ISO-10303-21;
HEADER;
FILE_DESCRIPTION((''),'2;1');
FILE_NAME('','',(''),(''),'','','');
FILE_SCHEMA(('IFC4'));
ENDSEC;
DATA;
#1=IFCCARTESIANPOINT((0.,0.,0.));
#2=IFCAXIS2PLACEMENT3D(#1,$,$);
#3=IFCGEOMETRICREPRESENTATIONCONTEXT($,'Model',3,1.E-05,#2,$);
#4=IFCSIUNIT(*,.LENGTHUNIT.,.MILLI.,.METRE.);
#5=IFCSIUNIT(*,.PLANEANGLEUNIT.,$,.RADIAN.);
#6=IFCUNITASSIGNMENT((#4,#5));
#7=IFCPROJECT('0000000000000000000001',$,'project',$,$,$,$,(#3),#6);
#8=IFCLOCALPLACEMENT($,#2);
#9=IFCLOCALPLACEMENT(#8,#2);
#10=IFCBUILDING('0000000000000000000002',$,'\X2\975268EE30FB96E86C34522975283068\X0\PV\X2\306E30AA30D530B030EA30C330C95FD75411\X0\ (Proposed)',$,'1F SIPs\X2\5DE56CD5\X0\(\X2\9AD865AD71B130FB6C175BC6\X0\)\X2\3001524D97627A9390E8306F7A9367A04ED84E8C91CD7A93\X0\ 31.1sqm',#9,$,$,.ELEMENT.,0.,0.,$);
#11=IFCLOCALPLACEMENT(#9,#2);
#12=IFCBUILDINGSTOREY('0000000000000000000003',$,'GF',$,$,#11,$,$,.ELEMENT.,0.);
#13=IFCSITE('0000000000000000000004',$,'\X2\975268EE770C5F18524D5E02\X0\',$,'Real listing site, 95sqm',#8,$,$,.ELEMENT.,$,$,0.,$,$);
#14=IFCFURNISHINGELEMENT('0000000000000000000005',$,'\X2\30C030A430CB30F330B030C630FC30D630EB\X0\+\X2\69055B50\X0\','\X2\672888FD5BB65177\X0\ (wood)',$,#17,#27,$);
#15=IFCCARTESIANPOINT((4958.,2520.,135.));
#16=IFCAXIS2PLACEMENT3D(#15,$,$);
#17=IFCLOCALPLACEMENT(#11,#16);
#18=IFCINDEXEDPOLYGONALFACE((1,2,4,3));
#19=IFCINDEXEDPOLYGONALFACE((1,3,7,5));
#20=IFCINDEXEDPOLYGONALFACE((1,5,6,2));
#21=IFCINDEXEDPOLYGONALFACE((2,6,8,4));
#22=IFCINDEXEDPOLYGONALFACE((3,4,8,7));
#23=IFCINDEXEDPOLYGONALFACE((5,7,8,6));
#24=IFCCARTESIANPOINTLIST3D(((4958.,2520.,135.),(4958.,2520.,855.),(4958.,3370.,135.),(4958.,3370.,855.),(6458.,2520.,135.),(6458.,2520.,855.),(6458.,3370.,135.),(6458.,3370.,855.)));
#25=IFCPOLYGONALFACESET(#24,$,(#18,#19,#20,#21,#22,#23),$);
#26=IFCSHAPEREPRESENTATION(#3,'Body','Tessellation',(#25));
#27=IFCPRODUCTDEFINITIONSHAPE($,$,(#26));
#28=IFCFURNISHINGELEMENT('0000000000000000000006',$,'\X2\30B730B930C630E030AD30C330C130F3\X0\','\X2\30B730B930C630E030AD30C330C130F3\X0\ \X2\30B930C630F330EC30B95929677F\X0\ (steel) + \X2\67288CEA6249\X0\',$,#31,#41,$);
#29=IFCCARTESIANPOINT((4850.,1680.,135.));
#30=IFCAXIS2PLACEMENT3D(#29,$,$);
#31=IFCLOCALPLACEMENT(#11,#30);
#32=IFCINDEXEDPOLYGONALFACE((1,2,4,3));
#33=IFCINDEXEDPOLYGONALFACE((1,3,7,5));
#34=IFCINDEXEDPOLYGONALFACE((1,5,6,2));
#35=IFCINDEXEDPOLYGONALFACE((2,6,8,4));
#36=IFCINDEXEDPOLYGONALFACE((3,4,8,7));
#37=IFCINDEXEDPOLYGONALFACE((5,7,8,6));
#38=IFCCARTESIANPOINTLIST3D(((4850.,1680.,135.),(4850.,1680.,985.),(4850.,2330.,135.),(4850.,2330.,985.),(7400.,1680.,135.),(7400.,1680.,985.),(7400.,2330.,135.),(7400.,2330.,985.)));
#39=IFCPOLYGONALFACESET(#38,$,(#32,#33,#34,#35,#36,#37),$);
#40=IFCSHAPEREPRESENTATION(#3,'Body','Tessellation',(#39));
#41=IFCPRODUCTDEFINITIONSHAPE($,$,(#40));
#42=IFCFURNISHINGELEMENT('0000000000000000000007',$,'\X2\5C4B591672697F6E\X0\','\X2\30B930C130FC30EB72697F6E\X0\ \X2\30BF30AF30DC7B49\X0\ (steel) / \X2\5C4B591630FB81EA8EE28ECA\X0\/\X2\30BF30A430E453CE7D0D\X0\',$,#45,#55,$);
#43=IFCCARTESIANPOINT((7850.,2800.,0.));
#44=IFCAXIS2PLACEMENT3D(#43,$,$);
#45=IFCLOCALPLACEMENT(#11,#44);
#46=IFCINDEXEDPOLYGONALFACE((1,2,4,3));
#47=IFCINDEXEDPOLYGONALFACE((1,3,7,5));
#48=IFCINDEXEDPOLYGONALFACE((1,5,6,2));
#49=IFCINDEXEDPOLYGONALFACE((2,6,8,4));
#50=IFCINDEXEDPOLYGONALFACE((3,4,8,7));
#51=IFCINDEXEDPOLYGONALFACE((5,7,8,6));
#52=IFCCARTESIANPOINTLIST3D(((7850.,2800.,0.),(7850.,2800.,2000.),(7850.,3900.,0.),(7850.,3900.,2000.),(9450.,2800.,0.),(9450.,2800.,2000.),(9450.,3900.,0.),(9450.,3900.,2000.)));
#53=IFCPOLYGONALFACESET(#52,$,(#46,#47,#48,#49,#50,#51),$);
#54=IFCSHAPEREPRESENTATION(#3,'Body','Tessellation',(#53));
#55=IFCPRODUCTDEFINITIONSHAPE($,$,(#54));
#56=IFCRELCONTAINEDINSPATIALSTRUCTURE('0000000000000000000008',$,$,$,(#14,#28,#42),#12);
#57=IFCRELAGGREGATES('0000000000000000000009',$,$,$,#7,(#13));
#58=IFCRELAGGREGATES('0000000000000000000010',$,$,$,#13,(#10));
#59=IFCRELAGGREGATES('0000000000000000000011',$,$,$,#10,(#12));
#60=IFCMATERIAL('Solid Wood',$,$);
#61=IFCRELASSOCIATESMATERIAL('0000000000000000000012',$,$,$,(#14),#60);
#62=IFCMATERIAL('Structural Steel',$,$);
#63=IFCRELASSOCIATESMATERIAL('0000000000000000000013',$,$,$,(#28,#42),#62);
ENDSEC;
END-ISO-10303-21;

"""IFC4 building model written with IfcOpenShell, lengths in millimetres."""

from ifc_helpers import new_model, si_unit, frame, frame_2d, origin, place, context, project, spatial, rectangle, extrude, material, element, save


model = new_model("IFC4")

# Units and contexts
model_context = context("Model", 3, precision=1e-05, world=origin())
ifc_project = project(units=[si_unit("LENGTHUNIT", "METRE", prefix="MILLI"), si_unit("PLANEANGLEUNIT", "RADIAN")], contexts=[model_context])

# Site, building, storey
site_placement = place(None, origin())
site = spatial("IfcSite", under=ifc_project, at=site_placement, Name="青森県弘前市", ObjectType="Real listing site, 95sqm", CompositionType="ELEMENT", RefElevation=0.0)
building_placement = place(site_placement, origin())
building = spatial("IfcBuilding", under=site, at=building_placement, Name="青森・雨水利用とPVのオフグリッド志向 (Proposed)", ObjectType="1F SIPs工法(高断熱・気密)、前面窓部は窓枠付二重窓 31.1sqm", CompositionType="ELEMENT", ElevationOfRefHeight=0.0, ElevationOfTerrain=0.0)
storey_placement = place(building_placement, origin())
storey = spatial("IfcBuildingStorey", under=building, at=storey_placement, Name="GF", CompositionType="ELEMENT", Elevation=0.0)

# Shared definitions
ifc_material_1 = material(Name="Solid Wood")

# Shared definitions
ifc_material_2 = material(Name="Structural Steel")

# Furnishing elements
furnishing_1_placement = place(storey_placement, frame((4958.0, 2520.0, 135.0)))
element("IfcFurnishingElement", 1, at=furnishing_1_placement, inside=storey, material=ifc_material_1, Name="ダイニングテーブル+椅子", Description="木製家具 (wood)", context=model_context, shape_type="SweptSolid", body=[
    extrude(rectangle(XDim=1500.0, YDim=850.0, at=frame_2d((750.0, 425.0))), frame((4958.0, 2520.0, 135.0)), (0.0, 0.0, 1.0), 720.0),
])
furnishing_2_placement = place(storey_placement, frame((4850.0, 1680.0, 135.0)))
element("IfcFurnishingElement", 2, at=furnishing_2_placement, inside=storey, material=ifc_material_2, Name="システムキッチン", Description="システムキッチン ステンレス天板 (steel) + 木質扉", context=model_context, shape_type="SweptSolid", body=[
    extrude(rectangle(XDim=2550.0, YDim=650.0, at=frame_2d((1275.0, 325.0))), frame((4850.0, 1680.0, 135.0)), (0.0, 0.0, 1.0), 850.0),
])
furnishing_3_placement = place(storey_placement, frame((7850.0, 2800.0, 0.0)))
element("IfcFurnishingElement", 3, at=furnishing_3_placement, inside=storey, material=ifc_material_2, Name="屋外物置", Description="スチール物置 タクボ等 (steel) / 屋外・自転車/タイヤ収納", context=model_context, shape_type="SweptSolid", body=[
    extrude(rectangle(XDim=1600.0, YDim=1100.0, at=frame_2d((800.0, 550.0))), frame((7850.0, 2800.0, 0.0)), (0.0, 0.0, 1.0), 2000.0),
])

save(model, "model.ifc")
